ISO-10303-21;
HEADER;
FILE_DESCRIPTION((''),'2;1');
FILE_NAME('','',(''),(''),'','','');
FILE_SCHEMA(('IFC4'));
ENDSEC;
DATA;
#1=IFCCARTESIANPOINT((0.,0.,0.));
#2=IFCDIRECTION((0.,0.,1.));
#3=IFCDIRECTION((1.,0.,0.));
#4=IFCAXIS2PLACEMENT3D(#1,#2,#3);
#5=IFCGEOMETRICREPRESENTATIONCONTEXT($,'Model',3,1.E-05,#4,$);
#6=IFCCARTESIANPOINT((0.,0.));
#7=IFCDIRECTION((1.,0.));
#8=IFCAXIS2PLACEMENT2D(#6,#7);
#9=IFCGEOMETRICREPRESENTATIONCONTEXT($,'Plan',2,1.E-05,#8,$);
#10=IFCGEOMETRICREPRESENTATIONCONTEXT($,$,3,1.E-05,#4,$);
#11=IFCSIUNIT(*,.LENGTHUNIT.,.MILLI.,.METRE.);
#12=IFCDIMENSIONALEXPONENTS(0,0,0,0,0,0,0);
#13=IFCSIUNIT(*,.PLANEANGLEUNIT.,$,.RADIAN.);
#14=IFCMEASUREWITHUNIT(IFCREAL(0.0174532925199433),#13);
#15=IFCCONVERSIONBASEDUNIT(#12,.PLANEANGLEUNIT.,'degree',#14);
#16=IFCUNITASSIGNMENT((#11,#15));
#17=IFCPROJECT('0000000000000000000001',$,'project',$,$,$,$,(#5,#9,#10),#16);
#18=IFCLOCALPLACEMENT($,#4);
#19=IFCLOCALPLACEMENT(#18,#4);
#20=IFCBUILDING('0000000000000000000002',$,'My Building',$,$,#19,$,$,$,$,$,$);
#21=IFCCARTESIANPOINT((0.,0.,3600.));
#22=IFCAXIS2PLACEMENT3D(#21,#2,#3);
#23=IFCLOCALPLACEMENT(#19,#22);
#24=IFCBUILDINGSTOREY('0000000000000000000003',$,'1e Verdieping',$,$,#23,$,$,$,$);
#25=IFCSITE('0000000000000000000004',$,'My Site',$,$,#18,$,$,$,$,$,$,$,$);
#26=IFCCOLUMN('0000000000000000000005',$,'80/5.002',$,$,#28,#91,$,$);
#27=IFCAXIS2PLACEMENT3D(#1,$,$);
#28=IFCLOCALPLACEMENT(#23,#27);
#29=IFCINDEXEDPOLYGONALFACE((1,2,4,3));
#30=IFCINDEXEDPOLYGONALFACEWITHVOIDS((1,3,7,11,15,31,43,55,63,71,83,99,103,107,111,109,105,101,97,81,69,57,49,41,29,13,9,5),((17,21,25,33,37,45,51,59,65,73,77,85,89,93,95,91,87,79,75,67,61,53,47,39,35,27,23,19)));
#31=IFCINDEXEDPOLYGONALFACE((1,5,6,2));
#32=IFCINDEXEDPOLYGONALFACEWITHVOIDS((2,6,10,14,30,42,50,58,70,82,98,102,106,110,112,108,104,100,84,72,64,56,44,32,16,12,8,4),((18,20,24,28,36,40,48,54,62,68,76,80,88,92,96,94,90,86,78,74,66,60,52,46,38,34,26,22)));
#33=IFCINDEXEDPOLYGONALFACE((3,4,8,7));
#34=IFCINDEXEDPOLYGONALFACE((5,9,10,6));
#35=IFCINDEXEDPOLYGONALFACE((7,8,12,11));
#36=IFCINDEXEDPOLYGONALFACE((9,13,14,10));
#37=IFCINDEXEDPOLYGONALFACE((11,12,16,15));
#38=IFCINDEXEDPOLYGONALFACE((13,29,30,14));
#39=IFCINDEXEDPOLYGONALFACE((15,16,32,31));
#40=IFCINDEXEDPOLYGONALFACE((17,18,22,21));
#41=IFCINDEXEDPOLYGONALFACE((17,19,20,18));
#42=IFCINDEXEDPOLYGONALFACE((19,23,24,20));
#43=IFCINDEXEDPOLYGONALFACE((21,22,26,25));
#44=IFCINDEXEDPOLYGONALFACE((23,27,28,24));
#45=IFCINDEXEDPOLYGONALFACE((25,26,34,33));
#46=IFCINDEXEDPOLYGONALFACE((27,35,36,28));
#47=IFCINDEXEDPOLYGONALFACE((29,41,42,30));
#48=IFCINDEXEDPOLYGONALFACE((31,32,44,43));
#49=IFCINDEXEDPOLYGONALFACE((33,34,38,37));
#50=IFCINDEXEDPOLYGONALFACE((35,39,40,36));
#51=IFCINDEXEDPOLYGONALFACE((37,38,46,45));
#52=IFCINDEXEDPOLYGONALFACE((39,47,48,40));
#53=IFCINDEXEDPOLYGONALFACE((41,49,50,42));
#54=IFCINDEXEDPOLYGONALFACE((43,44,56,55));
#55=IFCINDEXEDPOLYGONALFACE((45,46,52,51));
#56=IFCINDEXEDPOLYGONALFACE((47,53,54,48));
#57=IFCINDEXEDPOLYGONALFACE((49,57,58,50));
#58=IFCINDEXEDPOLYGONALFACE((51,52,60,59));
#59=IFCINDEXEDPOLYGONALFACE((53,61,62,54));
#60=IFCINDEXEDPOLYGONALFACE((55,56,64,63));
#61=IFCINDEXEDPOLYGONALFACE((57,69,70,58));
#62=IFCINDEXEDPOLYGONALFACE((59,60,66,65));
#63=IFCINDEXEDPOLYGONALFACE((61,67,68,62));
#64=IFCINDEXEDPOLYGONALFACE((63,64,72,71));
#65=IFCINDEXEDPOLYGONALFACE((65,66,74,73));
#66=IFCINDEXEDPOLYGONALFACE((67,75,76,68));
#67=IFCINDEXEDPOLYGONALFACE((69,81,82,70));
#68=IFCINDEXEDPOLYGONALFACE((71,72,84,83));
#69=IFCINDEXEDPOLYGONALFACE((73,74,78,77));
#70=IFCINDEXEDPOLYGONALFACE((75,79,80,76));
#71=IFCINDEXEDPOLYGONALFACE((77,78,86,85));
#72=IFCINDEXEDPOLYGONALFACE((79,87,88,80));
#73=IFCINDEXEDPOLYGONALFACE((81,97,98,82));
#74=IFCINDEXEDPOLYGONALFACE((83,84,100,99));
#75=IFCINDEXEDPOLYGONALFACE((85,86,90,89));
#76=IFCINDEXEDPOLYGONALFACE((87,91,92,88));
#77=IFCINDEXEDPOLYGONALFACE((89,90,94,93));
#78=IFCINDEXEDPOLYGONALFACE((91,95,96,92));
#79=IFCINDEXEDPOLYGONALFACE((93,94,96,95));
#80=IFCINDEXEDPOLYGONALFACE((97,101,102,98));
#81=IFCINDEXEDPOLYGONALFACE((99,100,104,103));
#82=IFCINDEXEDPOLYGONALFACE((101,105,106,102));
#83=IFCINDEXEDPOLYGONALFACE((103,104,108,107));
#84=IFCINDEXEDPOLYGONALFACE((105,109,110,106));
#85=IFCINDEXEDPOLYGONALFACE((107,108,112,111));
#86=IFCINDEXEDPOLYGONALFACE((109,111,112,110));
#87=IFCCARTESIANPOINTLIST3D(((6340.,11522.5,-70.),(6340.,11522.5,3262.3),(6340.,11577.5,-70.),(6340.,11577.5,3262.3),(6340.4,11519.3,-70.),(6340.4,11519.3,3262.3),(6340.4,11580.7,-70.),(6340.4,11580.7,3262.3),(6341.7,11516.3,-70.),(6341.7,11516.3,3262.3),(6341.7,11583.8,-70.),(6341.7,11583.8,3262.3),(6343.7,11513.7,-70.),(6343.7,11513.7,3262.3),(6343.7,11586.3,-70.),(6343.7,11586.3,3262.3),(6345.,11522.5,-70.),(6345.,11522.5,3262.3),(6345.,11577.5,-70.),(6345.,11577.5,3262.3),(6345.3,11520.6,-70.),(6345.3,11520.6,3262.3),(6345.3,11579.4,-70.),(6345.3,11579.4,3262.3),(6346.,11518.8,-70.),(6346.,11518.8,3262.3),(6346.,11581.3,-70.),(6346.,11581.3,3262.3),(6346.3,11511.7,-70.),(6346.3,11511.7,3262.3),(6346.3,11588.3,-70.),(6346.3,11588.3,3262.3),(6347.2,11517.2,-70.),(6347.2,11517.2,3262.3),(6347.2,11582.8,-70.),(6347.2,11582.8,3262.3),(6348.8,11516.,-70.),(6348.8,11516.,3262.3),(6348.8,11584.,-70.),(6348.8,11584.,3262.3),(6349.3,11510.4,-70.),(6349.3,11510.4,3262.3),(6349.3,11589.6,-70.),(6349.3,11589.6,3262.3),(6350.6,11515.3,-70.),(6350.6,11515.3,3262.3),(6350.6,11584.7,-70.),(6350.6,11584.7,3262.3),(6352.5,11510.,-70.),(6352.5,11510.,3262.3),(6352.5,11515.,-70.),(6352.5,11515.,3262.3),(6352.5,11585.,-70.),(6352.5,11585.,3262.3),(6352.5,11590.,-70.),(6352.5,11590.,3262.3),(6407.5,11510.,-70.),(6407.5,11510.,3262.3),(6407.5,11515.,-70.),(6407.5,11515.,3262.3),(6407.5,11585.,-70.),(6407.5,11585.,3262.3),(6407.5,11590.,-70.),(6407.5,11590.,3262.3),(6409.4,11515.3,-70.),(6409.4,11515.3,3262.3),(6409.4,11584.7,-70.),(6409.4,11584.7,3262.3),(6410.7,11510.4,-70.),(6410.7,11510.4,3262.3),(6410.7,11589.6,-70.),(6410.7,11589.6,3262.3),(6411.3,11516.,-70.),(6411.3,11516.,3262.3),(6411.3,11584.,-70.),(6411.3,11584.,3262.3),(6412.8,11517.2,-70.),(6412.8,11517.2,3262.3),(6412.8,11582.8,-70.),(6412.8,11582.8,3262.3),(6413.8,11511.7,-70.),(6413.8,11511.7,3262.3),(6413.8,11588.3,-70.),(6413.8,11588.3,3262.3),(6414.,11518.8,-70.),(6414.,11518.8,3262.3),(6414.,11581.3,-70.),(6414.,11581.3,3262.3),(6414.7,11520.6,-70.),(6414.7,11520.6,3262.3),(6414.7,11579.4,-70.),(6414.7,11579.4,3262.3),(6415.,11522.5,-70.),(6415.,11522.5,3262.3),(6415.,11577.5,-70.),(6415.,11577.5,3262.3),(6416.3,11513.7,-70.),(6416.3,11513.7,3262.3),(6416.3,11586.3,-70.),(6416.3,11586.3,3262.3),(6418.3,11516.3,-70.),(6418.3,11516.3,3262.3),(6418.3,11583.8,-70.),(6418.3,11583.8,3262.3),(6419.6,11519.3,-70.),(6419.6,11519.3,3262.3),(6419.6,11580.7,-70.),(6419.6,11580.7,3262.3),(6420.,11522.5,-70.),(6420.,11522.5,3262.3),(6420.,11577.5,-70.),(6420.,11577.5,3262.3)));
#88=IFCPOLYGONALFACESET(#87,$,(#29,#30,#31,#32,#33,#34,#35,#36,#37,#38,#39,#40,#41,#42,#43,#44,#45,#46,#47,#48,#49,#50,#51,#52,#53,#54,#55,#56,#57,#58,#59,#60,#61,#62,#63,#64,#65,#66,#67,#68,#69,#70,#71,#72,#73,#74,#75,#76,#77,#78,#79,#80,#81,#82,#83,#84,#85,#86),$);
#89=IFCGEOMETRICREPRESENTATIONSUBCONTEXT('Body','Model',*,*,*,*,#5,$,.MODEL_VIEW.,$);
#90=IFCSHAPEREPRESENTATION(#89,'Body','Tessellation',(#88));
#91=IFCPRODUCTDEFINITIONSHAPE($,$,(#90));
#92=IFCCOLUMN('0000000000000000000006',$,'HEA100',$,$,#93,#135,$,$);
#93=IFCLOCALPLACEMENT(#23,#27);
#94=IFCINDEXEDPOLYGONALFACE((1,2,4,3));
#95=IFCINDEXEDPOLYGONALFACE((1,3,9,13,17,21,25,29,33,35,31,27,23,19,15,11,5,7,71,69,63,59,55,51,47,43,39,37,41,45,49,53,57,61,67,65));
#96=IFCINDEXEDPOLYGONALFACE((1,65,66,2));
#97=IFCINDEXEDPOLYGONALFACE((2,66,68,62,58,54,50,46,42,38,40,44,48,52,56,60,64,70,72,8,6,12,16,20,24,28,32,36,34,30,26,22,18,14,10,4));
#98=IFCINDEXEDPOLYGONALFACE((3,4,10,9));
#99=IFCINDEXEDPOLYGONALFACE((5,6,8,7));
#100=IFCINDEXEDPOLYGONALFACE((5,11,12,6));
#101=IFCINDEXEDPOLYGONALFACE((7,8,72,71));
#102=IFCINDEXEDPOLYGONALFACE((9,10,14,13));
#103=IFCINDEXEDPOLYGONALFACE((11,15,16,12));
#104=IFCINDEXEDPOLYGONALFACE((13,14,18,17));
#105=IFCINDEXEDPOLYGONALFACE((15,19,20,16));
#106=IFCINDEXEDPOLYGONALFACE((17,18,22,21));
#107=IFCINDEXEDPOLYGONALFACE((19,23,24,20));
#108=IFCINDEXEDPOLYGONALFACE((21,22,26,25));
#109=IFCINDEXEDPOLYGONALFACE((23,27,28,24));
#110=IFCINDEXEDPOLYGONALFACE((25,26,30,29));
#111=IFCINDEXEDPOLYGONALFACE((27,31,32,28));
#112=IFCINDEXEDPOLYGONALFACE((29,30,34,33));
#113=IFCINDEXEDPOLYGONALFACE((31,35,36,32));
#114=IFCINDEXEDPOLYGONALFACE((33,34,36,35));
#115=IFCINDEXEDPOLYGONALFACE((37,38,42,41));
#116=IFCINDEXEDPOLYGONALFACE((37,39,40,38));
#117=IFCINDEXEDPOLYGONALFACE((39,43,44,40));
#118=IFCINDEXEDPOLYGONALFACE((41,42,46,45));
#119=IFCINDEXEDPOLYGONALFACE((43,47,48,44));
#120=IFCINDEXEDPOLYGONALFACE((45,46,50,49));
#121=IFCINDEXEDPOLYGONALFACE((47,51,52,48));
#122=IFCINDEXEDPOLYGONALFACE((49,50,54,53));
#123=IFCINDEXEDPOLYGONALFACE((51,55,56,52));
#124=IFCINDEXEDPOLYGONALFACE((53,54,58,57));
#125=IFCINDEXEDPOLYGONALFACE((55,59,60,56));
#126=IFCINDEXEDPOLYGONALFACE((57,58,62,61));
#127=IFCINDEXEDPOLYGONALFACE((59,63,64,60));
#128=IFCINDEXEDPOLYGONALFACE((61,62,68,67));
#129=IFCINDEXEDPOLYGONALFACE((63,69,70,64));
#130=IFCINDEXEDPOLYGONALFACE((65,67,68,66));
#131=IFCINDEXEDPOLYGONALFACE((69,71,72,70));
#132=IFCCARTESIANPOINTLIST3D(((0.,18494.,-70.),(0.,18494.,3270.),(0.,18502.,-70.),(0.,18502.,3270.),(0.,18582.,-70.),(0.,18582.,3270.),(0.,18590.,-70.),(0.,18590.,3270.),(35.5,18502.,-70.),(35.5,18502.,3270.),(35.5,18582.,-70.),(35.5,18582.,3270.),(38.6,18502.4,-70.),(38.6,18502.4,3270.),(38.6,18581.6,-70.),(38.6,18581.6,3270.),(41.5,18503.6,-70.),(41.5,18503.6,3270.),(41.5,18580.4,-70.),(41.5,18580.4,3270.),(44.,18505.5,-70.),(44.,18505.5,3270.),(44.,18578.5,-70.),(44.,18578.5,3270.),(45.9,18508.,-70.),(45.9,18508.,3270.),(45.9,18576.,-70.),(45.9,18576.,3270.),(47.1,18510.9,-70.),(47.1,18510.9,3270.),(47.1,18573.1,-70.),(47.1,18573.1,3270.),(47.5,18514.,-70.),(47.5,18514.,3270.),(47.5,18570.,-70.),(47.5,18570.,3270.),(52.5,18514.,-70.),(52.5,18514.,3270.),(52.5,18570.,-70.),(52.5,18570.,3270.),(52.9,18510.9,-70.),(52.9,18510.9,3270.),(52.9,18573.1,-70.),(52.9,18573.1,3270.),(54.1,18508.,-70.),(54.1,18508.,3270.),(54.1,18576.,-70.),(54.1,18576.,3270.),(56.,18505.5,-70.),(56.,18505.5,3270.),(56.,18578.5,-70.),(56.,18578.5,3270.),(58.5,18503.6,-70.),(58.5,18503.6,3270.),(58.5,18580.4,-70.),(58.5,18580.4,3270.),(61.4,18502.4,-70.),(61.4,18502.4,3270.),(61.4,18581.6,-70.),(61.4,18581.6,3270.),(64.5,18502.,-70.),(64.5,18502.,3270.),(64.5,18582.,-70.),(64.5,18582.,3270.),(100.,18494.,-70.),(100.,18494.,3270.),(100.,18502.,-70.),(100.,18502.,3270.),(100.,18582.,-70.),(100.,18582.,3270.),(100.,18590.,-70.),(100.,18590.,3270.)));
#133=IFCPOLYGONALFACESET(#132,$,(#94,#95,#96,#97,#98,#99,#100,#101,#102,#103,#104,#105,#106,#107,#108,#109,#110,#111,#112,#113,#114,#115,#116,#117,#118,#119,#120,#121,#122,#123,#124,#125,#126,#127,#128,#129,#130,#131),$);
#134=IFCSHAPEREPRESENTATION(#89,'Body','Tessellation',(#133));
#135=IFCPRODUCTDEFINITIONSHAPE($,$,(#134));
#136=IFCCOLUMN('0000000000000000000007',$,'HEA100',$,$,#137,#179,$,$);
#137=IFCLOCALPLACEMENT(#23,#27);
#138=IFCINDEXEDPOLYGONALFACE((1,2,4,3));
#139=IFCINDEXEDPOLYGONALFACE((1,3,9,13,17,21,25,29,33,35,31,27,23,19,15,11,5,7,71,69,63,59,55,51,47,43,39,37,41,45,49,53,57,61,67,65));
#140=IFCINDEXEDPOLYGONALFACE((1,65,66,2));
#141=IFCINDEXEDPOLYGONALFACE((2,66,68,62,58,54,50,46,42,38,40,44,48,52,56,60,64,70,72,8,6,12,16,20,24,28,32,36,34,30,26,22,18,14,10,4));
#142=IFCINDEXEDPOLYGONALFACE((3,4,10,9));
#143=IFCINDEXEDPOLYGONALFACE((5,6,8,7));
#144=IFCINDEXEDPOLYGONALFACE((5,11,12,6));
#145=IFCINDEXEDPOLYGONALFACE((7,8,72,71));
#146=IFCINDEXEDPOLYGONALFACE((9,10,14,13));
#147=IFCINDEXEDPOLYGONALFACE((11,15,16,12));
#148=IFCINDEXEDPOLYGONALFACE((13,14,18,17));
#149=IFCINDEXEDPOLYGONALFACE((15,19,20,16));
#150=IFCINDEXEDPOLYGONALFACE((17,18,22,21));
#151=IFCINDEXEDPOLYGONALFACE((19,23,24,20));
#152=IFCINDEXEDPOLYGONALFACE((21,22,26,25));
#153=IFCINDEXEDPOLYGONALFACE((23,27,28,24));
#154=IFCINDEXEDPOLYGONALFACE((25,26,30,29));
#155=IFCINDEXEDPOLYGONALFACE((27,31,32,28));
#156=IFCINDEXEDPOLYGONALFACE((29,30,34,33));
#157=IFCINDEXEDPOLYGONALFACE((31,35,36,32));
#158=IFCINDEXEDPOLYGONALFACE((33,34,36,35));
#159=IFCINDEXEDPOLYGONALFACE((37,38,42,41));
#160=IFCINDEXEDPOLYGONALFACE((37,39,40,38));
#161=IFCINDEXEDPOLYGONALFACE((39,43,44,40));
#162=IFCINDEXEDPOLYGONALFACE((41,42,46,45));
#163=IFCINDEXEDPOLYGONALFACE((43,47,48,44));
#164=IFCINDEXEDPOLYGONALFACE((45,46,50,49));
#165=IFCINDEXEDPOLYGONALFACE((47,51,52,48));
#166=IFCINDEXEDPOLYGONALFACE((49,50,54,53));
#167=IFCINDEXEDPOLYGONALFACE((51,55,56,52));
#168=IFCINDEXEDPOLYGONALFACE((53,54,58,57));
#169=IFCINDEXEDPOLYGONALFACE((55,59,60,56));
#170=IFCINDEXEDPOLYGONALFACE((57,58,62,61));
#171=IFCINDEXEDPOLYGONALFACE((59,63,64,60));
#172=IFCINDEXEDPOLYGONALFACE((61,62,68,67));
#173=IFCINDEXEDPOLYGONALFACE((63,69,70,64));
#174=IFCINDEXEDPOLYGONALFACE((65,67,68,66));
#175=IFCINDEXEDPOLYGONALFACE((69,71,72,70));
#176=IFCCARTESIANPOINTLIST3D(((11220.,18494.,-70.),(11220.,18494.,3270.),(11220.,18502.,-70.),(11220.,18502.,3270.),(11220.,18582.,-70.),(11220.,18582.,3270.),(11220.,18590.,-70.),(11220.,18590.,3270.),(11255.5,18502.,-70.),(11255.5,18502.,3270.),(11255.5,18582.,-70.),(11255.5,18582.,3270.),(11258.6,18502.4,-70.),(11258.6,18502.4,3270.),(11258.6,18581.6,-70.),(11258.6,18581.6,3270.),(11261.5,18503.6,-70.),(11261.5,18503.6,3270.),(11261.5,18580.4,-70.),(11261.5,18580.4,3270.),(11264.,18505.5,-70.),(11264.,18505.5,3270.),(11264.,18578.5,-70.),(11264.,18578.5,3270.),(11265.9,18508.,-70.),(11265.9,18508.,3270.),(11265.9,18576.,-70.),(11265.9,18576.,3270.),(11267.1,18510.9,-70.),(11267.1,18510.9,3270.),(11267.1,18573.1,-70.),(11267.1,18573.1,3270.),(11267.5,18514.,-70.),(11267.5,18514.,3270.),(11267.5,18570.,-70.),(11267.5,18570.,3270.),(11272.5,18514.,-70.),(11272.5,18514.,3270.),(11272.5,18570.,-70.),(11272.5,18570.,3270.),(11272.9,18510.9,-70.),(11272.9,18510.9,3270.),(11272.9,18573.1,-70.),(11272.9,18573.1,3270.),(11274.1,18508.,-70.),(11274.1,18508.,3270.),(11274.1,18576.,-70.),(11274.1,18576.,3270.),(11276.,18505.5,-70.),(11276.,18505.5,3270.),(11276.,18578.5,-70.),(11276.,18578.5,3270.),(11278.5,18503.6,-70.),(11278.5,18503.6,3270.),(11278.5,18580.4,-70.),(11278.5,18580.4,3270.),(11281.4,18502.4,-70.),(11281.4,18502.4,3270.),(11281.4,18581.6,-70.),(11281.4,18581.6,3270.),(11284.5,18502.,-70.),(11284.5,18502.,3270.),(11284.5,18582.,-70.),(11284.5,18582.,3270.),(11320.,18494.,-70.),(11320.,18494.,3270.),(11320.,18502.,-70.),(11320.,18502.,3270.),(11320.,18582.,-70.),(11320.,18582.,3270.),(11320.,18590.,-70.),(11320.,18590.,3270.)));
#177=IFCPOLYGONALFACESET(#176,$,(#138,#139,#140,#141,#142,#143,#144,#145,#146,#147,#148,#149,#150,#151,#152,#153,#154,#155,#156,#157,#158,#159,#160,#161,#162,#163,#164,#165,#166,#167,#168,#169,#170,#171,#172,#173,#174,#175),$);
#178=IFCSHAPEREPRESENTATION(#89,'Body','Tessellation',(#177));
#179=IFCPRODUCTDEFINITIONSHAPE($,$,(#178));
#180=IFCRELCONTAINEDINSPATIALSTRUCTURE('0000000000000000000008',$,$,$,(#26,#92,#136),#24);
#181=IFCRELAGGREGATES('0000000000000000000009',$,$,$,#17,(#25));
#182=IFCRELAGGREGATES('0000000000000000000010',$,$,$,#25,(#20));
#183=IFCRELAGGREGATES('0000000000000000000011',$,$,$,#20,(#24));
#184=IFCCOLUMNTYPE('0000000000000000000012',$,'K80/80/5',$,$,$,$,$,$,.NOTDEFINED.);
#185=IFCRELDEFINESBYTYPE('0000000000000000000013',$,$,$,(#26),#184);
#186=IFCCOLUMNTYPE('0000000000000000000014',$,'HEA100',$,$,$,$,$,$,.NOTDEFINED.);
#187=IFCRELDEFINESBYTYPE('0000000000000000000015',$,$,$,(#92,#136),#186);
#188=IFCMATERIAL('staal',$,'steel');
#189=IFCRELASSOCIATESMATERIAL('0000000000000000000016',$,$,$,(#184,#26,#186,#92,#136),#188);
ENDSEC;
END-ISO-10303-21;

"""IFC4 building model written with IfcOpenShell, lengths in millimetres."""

from ifc_helpers import new_model, entity, si_unit, converted_unit, frame, origin_with_axes, origin_2d_with_axis, place, context, subcontext, project, spatial, hollow_rectangle, i_section, extrude, material, material_profile, profile_set, profile_usage, type_object, element, save


model = new_model("IFC4")

# Units and contexts
model_context = context("Model", 3, precision=1e-05, world=origin_with_axes())
plan_context = context("Plan", 2, precision=1e-05, world=origin_2d_with_axis())
context_of_model = context(None, 3, precision=1e-05, world=origin_with_axes())
body_context = subcontext(model_context, "Body", "Model", "MODEL_VIEW")
ifc_project = project(units=[si_unit("LENGTHUNIT", "METRE", prefix="MILLI"), converted_unit("PLANEANGLEUNIT", "degree", entity("IfcReal", 0.0174532925199433), si_unit("PLANEANGLEUNIT", "RADIAN"), dimensions=[0, 0, 0, 0, 0, 0, 0])], contexts=[model_context, plan_context, context_of_model])

# Site, building, storey
site_placement = place(None, origin_with_axes())
site = spatial("IfcSite", under=ifc_project, at=site_placement, Name="My Site")
building_placement = place(site_placement, origin_with_axes())
building = spatial("IfcBuilding", under=site, at=building_placement, Name="My Building")
storey_placement = place(building_placement, frame((0.0, 0.0, 3600.0), z_axis=(0.0, 0.0, 1.0), x_axis=(1.0, 0.0, 0.0)))
storey = spatial("IfcBuildingStorey", under=building, at=storey_placement, Name="1e Verdieping")

# Columns
ifc_material_1 = material(Name="staal", Category="steel")
ifc_material_profile_1 = material_profile(ifc_material_1, hollow_rectangle(XDim=80.0, YDim=80.0, WallThickness=5.0, InnerFilletRadius=7.5, OuterFilletRadius=12.5))
ifc_profile_set_1 = profile_set([ifc_material_profile_1], Name="K80/80/5")
column_type_1 = type_object("IfcColumnType", Name="K80/80/5", PredefinedType="NOTDEFINED", material=ifc_profile_set_1)
ifc_profile_usage_1 = profile_usage(ifc_profile_set_1)
column_1_placement = place(storey_placement, frame((6380.0, 11550.0, -70.0), z_axis=(0.0, 0.0, 1.0), x_axis=(1.0, 0.0, 0.0)))
element("IfcColumn", 1, at=column_1_placement, inside=storey, type_object=column_type_1, material=ifc_profile_usage_1, Name="80/5.002", context=body_context, shape_type="SweptSolid", body=[
    extrude(hollow_rectangle(XDim=80.0, YDim=80.0, WallThickness=5.0, InnerFilletRadius=7.5, OuterFilletRadius=12.5), origin_with_axes(), (0.0, 0.0, 1.0), 3332.3),
])
ifc_material_profile_2 = material_profile(ifc_material_1, i_section(OverallWidth=100.0, OverallDepth=96.0, WebThickness=5.0, FlangeThickness=8.0, FilletRadius=12.0))
ifc_profile_set_2 = profile_set([ifc_material_profile_2], Name="HEA100")
ifc_profile_usage_2 = profile_usage(ifc_profile_set_2)
column_type_2 = type_object("IfcColumnType", Name="HEA100", PredefinedType="NOTDEFINED", material=ifc_profile_set_2)
column_2_placement = place(storey_placement, frame((50.0, 18542.0, -70.0), z_axis=(0.0, 0.0, 1.0), x_axis=(1.0, 0.0, 0.0)))
element("IfcColumn", 2, at=column_2_placement, inside=storey, type_object=column_type_2, material=ifc_profile_usage_2, Name="HEA100", context=body_context, shape_type="SweptSolid", body=[
    extrude(i_section(OverallWidth=100.0, OverallDepth=96.0, WebThickness=5.0, FlangeThickness=8.0, FilletRadius=12.0), origin_with_axes(), (0.0, 0.0, 1.0), 3340.0),
])
ifc_profile_usage_3 = profile_usage(ifc_profile_set_2)
column_3_placement = place(storey_placement, frame((11270.0, 18542.0, -70.0), z_axis=(0.0, 0.0, 1.0), x_axis=(1.0, 0.0, 0.0)))
element("IfcColumn", 3, at=column_3_placement, inside=storey, type_object=column_type_2, material=ifc_profile_usage_3, Name="HEA100", context=body_context, shape_type="SweptSolid", body=[
    extrude(i_section(OverallWidth=100.0, OverallDepth=96.0, WebThickness=5.0, FlangeThickness=8.0, FilletRadius=12.0), origin_with_axes(), (0.0, 0.0, 1.0), 3340.0),
])

save(model, "model.ifc")
